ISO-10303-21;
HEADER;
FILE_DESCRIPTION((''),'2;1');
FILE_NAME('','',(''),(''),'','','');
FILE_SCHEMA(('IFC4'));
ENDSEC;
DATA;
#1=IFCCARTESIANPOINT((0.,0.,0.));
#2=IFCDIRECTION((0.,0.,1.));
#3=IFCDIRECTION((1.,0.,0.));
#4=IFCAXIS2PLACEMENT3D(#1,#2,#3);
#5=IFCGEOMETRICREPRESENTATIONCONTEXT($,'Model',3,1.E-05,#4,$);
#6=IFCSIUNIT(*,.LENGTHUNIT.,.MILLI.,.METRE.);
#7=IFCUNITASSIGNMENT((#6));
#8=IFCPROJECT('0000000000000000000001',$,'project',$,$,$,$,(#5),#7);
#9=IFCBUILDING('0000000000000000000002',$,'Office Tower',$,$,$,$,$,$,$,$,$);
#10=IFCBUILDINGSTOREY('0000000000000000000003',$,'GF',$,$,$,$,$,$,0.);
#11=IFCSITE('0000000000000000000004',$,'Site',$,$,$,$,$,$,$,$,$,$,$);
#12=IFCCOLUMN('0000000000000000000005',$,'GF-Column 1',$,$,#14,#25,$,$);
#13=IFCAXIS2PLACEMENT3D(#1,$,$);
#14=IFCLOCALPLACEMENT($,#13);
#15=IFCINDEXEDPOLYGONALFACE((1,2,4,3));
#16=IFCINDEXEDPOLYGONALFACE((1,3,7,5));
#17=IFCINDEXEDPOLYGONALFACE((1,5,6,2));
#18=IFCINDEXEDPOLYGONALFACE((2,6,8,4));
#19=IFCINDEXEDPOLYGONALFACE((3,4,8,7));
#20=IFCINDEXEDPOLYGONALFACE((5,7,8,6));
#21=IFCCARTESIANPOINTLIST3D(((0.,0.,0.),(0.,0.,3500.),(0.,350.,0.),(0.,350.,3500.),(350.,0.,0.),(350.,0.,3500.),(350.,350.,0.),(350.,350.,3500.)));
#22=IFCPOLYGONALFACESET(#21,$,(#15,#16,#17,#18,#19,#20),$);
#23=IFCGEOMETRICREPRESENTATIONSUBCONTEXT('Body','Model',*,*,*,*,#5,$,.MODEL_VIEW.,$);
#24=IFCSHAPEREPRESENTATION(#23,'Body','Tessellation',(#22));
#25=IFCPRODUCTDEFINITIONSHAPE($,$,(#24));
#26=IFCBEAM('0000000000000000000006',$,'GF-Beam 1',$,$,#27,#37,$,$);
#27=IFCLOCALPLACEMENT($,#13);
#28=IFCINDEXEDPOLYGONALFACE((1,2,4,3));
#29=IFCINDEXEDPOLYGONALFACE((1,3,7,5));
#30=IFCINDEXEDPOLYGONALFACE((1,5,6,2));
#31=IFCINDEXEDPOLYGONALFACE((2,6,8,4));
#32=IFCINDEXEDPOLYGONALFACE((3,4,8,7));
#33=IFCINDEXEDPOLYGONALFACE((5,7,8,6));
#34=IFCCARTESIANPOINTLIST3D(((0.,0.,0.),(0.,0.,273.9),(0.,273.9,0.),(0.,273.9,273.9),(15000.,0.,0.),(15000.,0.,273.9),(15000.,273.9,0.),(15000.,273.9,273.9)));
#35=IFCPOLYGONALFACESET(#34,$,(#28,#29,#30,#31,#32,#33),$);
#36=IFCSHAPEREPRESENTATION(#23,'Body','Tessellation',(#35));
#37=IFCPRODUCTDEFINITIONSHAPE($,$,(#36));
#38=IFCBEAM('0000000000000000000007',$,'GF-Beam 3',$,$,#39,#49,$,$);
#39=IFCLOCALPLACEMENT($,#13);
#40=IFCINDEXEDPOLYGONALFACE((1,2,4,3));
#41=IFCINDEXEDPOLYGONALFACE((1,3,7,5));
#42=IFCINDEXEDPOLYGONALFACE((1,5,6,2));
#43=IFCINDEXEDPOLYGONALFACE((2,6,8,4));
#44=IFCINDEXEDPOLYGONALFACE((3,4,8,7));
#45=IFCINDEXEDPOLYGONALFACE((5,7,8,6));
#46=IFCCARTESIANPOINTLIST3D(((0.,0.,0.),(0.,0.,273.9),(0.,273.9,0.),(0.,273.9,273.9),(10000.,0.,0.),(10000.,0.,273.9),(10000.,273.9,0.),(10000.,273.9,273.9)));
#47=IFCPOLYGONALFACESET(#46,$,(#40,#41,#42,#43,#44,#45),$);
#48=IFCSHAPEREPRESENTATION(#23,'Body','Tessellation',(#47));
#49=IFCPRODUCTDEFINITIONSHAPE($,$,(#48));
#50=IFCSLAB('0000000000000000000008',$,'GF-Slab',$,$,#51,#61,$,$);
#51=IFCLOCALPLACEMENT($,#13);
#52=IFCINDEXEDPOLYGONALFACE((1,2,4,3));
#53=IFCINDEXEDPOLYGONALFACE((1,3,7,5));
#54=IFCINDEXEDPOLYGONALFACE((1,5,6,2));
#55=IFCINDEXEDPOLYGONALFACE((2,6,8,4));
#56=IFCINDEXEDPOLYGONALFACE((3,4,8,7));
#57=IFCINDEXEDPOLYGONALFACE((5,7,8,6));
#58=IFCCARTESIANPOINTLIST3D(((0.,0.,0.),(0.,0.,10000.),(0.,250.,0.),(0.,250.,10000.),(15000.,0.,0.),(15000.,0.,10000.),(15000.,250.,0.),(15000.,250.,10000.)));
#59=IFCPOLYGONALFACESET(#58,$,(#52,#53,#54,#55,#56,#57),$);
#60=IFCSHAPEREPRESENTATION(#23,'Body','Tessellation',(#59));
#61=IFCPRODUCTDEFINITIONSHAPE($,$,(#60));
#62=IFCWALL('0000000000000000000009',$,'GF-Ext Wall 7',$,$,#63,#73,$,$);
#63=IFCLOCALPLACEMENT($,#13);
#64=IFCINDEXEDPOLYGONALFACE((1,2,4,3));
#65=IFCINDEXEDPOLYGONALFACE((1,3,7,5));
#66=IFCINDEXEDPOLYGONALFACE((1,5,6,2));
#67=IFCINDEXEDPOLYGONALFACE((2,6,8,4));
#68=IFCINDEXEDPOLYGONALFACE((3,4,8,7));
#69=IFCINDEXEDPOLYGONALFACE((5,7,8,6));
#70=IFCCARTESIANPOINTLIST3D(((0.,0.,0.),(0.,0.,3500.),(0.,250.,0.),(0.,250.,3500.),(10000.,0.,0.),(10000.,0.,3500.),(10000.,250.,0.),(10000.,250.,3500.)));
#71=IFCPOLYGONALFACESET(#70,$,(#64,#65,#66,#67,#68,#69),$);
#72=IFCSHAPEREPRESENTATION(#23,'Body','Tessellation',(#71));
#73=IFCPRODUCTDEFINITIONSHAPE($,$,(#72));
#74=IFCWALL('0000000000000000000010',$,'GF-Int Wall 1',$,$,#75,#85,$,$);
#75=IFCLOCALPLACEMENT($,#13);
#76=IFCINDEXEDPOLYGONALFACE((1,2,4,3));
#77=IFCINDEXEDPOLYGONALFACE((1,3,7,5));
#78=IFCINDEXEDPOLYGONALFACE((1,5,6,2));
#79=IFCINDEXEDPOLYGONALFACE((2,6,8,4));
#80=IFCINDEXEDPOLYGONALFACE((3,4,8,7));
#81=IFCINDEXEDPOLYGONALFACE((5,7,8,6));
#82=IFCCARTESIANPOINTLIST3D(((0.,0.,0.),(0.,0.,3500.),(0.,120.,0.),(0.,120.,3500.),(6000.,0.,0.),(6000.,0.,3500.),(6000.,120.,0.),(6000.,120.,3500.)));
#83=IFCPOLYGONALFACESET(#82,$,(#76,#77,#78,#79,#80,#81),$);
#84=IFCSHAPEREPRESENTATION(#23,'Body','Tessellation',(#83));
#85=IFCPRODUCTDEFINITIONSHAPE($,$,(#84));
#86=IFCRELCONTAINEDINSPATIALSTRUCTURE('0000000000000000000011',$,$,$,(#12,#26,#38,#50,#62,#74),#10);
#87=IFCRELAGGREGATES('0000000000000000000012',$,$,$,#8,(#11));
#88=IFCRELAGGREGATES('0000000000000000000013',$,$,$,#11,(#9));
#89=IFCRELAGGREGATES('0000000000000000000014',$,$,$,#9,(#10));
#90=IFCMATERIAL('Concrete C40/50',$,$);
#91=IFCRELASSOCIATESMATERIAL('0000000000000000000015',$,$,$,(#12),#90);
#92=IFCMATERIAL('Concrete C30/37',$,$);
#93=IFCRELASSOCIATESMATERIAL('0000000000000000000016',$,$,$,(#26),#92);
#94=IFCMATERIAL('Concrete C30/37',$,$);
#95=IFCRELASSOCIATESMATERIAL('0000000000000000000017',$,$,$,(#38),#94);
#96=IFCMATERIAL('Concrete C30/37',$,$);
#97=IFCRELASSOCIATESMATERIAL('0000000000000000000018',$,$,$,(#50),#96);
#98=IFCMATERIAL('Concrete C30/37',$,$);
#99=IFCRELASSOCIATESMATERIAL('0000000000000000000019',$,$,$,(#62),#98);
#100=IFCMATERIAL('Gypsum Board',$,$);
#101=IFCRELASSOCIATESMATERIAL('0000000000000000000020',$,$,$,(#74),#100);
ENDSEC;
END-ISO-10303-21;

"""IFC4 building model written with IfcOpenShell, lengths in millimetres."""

from ifc_helpers import new_model, si_unit, origin_with_axes, context, subcontext, project, spatial, indexed_curve, outline, extrude, material, element, save


model = new_model("IFC4")

# Units and contexts
model_context = context("Model", 3, precision=1e-05, world=origin_with_axes())
body_context = subcontext(model_context, "Body", "Model", "MODEL_VIEW")
ifc_project = project(units=[si_unit("LENGTHUNIT", "METRE", prefix="MILLI")], contexts=[model_context])

# Site, building, storey
site = spatial("IfcSite", under=ifc_project, Name="Site")
building = spatial("IfcBuilding", under=site, Name="Office Tower")
storey = spatial("IfcBuildingStorey", under=building, Name="GF", Elevation=0.0)

# Column
ifc_material_1 = material(Name="Concrete C40/50")
element("IfcColumn", 1, inside=storey, material=ifc_material_1, Name="GF-Column 1", context=body_context, shape_type="SweptSolid", body=[
    extrude(outline(indexed_curve([(0.0, 0.0), (0.0, 350.0), (350.0, 350.0), (350.0, 0.0), (0.0, 0.0)], self_intersect=False)), origin_with_axes(), (0.0, 0.0, 1.0), 3500.0),
])

# Beams
ifc_material_2 = material(Name="Concrete C30/37")
element("IfcBeam", 2, inside=storey, material=ifc_material_2, Name="GF-Beam 1", context=body_context, shape_type="SweptSolid", body=[
    extrude(outline(indexed_curve([(0.0, 0.0), (0.0, 273.9), (15000.0, 273.9), (15000.0, 0.0), (0.0, 0.0)], self_intersect=False)), origin_with_axes(), (0.0, 0.0, 1.0), 273.9),
])
ifc_material_3 = material(Name="Concrete C30/37")
element("IfcBeam", 3, inside=storey, material=ifc_material_3, Name="GF-Beam 3", context=body_context, shape_type="SweptSolid", body=[
    extrude(outline(indexed_curve([(0.0, 0.0), (0.0, 273.9), (10000.0, 273.9), (10000.0, 0.0), (0.0, 0.0)], self_intersect=False)), origin_with_axes(), (0.0, 0.0, 1.0), 273.9),
])

# Slab
ifc_material_4 = material(Name="Concrete C30/37")
element("IfcSlab", 4, inside=storey, material=ifc_material_4, Name="GF-Slab", context=body_context, shape_type="SweptSolid", body=[
    extrude(outline(indexed_curve([(0.0, 0.0), (0.0, 250.0), (15000.0, 250.0), (15000.0, 0.0), (0.0, 0.0)], self_intersect=False)), origin_with_axes(), (0.0, 0.0, 1.0), 10000.0),
])

# Walls
ifc_material_5 = material(Name="Concrete C30/37")
element("IfcWall", 5, inside=storey, material=ifc_material_5, Name="GF-Ext Wall 7", context=body_context, shape_type="SweptSolid", body=[
    extrude(outline(indexed_curve([(0.0, 0.0), (0.0, 250.0), (10000.0, 250.0), (10000.0, 0.0), (0.0, 0.0)], self_intersect=False)), origin_with_axes(), (0.0, 0.0, 1.0), 3500.0),
])
ifc_material_6 = material(Name="Gypsum Board")
element("IfcWall", 6, inside=storey, material=ifc_material_6, Name="GF-Int Wall 1", context=body_context, shape_type="SweptSolid", body=[
    extrude(outline(indexed_curve([(0.0, 0.0), (0.0, 120.0), (6000.0, 120.0), (6000.0, 0.0), (0.0, 0.0)], self_intersect=False)), origin_with_axes(), (0.0, 0.0, 1.0), 3500.0),
])

save(model, "model.ifc")
